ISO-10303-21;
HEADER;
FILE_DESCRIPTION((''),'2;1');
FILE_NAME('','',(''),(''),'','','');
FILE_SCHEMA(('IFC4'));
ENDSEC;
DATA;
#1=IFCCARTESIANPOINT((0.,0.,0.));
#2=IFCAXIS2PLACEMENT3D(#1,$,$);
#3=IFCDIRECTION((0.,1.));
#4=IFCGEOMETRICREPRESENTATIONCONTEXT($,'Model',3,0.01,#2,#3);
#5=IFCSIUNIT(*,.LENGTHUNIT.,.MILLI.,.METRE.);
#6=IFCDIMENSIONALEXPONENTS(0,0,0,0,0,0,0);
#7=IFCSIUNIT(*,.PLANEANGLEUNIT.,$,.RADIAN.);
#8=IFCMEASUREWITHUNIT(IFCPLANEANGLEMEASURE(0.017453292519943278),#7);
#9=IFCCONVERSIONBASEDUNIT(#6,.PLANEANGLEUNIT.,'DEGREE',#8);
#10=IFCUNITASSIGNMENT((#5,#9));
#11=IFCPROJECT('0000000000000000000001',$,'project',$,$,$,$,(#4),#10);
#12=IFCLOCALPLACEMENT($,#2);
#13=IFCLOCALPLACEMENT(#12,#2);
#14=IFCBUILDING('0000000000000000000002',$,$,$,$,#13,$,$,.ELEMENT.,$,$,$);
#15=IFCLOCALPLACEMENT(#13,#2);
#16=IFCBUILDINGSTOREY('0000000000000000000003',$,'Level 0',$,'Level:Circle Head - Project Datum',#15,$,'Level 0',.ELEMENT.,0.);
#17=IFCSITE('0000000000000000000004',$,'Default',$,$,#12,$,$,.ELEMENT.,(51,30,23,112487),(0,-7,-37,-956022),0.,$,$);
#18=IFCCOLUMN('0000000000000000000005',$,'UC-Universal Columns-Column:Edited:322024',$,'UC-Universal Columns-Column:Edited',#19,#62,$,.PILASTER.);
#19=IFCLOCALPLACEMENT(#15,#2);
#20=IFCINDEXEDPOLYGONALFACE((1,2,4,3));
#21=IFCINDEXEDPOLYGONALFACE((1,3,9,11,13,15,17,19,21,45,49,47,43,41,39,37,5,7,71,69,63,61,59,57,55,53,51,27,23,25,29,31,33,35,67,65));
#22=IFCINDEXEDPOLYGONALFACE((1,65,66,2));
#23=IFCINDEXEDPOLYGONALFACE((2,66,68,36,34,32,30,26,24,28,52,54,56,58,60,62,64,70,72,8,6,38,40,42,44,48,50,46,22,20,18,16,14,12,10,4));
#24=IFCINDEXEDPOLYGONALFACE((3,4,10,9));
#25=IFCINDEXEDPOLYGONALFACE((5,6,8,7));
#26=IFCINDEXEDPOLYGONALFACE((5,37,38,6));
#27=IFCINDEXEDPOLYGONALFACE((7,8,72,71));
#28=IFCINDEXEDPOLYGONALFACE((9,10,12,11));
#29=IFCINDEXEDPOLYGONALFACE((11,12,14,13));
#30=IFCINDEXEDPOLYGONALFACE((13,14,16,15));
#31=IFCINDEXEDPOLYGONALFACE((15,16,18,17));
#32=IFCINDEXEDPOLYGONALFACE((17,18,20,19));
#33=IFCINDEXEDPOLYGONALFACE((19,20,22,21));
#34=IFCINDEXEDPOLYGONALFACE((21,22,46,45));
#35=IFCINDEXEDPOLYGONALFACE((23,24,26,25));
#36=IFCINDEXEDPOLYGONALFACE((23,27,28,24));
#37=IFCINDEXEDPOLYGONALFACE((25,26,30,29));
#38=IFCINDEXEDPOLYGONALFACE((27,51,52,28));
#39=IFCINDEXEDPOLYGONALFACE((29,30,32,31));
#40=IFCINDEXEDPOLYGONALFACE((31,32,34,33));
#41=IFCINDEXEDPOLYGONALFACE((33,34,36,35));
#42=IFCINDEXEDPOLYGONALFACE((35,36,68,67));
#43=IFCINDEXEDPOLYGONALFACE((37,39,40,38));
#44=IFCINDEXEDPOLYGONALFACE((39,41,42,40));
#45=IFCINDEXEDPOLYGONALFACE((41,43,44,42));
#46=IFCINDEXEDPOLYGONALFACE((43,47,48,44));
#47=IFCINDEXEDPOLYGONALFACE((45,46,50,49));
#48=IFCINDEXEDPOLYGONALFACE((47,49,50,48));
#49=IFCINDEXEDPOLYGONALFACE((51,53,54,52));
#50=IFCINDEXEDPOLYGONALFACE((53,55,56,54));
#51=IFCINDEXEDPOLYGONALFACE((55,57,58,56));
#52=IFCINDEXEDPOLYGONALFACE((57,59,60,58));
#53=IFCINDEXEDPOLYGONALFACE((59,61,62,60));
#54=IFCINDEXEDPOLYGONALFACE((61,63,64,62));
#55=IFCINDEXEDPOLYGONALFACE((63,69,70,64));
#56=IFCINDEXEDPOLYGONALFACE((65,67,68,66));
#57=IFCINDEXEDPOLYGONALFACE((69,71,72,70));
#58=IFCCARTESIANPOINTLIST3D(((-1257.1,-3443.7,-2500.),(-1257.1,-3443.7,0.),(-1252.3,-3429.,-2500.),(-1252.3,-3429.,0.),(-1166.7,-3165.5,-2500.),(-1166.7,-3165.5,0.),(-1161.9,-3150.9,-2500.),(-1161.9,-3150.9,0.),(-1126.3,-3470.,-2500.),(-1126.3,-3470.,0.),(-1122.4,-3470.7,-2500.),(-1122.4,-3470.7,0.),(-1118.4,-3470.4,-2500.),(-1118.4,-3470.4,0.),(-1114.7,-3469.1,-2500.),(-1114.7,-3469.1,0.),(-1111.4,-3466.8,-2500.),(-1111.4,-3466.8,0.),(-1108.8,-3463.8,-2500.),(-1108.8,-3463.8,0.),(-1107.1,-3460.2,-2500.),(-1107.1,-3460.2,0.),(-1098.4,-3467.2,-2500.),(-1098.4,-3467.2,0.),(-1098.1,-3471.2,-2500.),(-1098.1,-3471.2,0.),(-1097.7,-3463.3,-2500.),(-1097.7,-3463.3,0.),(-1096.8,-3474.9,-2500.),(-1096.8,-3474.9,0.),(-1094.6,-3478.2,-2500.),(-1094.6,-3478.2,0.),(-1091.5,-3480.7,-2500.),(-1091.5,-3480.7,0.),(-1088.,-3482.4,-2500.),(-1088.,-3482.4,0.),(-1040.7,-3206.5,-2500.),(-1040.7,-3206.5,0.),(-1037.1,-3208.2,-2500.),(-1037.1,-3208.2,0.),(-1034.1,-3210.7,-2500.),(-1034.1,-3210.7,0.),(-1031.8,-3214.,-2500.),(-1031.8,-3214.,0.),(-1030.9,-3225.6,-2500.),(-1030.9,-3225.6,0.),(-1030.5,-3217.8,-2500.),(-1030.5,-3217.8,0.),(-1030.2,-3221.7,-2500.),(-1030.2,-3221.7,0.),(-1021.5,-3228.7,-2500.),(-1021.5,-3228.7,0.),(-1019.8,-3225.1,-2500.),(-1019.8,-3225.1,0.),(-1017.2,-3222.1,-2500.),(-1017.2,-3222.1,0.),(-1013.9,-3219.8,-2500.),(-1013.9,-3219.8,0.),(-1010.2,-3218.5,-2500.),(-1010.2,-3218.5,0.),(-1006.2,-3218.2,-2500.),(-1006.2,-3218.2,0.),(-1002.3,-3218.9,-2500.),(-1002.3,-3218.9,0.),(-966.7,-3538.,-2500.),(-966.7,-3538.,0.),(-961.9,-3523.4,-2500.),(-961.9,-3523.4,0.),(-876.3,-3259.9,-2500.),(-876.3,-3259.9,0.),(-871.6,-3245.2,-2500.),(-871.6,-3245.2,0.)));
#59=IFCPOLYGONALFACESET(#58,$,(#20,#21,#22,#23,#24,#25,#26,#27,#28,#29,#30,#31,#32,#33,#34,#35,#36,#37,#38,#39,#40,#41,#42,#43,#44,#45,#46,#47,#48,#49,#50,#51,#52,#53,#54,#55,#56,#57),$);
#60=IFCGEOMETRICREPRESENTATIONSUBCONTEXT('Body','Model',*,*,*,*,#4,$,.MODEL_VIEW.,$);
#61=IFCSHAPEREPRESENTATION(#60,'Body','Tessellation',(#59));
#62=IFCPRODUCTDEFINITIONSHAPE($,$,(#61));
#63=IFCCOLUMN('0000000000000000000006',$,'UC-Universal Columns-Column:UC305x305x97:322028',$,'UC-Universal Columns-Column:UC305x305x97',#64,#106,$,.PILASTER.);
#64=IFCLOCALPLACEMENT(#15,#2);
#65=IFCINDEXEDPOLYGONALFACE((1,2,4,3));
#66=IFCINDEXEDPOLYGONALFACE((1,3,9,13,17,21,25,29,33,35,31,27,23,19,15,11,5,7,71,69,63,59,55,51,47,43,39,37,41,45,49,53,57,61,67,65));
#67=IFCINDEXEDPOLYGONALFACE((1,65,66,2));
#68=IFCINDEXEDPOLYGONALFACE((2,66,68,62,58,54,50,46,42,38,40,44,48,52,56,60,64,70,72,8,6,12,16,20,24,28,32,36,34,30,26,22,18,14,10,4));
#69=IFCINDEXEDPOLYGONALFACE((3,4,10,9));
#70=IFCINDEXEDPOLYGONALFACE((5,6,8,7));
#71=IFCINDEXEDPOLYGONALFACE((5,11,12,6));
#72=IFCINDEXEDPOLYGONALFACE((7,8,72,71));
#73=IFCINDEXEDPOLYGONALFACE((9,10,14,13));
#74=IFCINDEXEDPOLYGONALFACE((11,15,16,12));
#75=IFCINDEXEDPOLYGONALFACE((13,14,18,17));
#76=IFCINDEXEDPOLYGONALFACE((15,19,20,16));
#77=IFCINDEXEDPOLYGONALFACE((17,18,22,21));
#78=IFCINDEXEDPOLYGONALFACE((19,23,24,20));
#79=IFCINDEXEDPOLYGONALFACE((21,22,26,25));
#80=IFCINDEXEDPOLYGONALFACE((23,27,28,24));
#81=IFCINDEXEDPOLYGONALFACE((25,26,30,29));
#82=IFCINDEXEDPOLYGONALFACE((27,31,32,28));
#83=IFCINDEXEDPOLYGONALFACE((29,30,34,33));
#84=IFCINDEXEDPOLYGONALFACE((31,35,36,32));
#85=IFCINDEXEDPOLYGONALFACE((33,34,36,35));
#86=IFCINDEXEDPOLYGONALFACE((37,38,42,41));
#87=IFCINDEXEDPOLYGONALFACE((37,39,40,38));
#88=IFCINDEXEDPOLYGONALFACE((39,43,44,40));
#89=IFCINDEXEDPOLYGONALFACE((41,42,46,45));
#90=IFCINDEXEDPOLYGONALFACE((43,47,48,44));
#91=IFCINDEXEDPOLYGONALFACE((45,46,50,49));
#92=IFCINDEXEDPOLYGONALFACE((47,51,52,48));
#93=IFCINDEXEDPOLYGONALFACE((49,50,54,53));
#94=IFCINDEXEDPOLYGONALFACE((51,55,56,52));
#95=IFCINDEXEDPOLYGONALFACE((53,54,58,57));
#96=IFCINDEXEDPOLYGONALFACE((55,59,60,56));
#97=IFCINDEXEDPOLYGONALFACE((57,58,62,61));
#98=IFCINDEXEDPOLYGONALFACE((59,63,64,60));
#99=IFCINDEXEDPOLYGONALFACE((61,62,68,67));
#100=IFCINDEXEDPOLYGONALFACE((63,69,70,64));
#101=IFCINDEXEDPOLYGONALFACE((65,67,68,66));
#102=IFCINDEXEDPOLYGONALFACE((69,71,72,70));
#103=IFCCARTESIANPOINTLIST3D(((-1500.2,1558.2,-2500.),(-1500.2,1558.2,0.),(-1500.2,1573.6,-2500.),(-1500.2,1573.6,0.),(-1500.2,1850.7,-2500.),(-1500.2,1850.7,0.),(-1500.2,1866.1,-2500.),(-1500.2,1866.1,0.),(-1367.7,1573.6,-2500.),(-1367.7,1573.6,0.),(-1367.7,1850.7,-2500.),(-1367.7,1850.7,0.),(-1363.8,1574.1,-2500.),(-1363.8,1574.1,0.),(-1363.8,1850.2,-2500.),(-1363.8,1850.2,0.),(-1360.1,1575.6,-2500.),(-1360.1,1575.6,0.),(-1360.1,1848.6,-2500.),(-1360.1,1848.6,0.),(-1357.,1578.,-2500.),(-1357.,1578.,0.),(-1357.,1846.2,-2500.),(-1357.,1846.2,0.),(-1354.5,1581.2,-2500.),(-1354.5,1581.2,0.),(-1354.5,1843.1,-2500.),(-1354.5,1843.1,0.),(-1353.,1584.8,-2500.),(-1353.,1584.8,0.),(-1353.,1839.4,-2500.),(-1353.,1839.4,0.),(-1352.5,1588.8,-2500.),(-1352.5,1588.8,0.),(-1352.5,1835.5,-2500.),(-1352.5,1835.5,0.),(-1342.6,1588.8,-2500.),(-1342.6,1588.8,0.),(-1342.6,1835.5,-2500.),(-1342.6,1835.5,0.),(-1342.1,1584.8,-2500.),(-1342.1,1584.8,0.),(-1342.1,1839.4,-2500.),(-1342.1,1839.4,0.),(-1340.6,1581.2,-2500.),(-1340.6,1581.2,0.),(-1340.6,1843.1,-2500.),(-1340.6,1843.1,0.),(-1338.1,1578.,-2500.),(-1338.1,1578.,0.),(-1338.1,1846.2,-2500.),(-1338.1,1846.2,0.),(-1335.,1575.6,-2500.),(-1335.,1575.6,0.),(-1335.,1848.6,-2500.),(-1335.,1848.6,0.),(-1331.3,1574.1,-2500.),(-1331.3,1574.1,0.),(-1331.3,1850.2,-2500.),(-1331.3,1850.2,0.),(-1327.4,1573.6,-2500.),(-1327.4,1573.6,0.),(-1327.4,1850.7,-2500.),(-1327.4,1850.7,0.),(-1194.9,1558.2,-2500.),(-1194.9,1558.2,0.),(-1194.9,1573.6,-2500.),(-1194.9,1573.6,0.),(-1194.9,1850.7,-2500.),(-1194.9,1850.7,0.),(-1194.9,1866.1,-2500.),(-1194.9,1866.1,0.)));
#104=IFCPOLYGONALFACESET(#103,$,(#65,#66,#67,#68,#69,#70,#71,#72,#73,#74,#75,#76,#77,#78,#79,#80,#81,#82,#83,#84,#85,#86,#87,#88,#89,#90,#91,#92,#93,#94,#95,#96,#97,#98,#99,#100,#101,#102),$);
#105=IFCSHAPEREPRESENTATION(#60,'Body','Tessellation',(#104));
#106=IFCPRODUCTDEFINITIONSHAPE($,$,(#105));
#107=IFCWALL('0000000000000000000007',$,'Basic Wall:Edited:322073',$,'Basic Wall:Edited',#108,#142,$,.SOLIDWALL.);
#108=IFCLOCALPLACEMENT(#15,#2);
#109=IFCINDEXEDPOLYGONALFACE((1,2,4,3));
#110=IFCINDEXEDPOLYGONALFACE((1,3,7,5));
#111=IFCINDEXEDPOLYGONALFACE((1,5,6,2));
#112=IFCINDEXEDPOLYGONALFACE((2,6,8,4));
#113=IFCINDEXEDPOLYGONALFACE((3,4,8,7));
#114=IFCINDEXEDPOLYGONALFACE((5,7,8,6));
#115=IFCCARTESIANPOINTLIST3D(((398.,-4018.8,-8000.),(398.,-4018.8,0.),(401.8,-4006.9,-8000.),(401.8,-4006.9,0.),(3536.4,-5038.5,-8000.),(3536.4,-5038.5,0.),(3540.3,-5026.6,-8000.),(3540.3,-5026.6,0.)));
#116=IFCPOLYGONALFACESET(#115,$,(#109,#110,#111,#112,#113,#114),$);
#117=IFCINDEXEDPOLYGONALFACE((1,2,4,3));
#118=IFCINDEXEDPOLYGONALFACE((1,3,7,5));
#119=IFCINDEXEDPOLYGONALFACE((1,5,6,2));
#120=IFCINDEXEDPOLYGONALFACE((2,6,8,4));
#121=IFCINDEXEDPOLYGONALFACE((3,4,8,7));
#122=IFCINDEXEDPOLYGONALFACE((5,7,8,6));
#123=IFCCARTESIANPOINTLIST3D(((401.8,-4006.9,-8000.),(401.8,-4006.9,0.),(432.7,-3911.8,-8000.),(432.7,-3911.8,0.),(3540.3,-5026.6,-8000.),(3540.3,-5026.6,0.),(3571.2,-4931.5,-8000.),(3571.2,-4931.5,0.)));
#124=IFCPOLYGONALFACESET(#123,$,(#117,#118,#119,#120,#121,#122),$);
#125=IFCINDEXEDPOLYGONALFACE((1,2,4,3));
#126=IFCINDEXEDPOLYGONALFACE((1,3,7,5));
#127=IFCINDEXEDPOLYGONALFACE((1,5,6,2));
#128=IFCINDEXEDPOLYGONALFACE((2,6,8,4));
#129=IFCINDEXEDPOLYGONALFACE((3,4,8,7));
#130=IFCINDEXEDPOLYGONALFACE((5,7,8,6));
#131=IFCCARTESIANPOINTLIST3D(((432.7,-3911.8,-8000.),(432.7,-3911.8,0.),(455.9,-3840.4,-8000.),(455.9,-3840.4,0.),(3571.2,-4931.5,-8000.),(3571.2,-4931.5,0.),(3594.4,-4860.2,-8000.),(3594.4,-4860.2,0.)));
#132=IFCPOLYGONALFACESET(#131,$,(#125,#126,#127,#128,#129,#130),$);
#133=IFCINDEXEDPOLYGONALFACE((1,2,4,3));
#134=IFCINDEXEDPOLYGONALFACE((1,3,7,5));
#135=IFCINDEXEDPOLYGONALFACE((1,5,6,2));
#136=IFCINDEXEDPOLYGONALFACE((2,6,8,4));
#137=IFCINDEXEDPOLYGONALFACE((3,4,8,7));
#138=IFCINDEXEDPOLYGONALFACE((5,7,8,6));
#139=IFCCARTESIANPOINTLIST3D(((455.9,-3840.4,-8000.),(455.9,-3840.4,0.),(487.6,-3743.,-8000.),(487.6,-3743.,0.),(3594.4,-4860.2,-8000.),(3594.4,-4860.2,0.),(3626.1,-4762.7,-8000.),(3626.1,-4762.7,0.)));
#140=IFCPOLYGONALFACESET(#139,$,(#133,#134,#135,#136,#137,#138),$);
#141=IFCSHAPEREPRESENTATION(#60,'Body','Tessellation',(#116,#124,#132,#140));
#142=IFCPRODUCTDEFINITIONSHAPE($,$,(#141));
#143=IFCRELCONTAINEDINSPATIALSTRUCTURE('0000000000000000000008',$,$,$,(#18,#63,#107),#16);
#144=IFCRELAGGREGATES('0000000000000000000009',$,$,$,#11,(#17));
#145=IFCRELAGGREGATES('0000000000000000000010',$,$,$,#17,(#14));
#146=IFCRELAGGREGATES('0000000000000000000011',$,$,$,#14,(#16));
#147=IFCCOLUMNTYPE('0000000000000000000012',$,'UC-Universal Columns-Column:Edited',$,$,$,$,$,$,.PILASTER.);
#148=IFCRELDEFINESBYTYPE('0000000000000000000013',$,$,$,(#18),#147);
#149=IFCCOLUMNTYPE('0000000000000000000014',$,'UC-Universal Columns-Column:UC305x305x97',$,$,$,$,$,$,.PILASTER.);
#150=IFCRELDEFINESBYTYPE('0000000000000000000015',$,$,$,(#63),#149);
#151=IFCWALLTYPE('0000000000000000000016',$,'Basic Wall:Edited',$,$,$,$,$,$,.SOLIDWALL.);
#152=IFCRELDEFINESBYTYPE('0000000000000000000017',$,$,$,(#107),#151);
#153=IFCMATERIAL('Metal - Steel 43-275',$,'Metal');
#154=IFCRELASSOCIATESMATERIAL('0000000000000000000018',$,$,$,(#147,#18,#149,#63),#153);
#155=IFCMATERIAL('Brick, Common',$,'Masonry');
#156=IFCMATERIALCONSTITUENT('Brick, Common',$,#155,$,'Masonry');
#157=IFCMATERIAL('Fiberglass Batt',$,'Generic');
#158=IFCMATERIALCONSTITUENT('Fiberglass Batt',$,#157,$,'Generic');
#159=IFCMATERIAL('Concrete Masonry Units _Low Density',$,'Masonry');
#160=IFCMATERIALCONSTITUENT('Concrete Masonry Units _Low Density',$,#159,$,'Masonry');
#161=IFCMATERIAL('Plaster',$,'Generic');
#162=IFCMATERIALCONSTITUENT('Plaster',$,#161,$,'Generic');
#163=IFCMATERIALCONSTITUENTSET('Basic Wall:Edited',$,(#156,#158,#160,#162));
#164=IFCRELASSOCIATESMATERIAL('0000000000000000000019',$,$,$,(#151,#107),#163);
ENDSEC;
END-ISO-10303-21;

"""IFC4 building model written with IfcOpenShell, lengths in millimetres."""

from ifc_helpers import new_model, entity, si_unit, converted_unit, direction, frame, origin, place, context, subcontext, project, spatial, line, arc, indexed_curve, outline, extrude, source, transform, mapped, material, constituent, constituent_set, type_object, type_shapes, element, save


model = new_model("IFC4")

# Units and contexts
model_context = context("Model", 3, precision=0.01, world=origin(), true_north=direction((0.0, 1.0)))
body_context = subcontext(model_context, "Body", "Model", "MODEL_VIEW")
ifc_project = project(units=[si_unit("LENGTHUNIT", "METRE", prefix="MILLI"), converted_unit("PLANEANGLEUNIT", "DEGREE", entity("IfcPlaneAngleMeasure", 0.017453292519943278), si_unit("PLANEANGLEUNIT", "RADIAN"), dimensions=[0, 0, 0, 0, 0, 0, 0])], contexts=[model_context])

# Site, building, storey
site_placement = place(None, origin())
site = spatial("IfcSite", under=ifc_project, at=site_placement, Name="Default", CompositionType="ELEMENT", RefLatitude=(51, 30, 23, 112487), RefLongitude=(0, -7, -37, -956022), RefElevation=0.0)
building_placement = place(site_placement, origin())
building = spatial("IfcBuilding", under=site, at=building_placement, CompositionType="ELEMENT")
storey_placement = place(building_placement, origin())
storey = spatial("IfcBuildingStorey", under=building, at=storey_placement, Name="Level 0", ObjectType="Level:Circle Head - Project Datum", LongName="Level 0", CompositionType="ELEMENT", Elevation=0.0)

# Columns
ifc_material_1 = material(Name="Metal - Steel 43-275", Category="Metal")
column_type_1 = type_object("IfcColumnType", Name="UC-Universal Columns-Column:Edited", PredefinedType="PILASTER", material=ifc_material_1)
shared_shape_1 = source(origin(), body_context, "Body", "SweptSolid", [
    extrude(outline(indexed_curve([(-152.6, -153.9), (152.6, -153.9), (152.6, -138.5), (20.2, -138.5), (9.4, -134.1), (4.9, -123.4), (4.9, 123.3), (9.4, 134.1), (20.1, 138.5), (152.6, 138.5), (152.6, 153.9), (-152.6, 153.9), (-152.6, 138.5), (-20.2, 138.6), (-9.4, 134.1), (-5.0, 123.4), (-5.0, -123.3), (-9.4, -134.1), (-20.2, -138.5), (-152.6, -138.5)], segments=[line(1, 2, 3, 4), arc(4, 5, 6), line(6, 7), arc(7, 8, 9), line(9, 10, 11, 12, 13, 14), arc(14, 15, 16), line(16, 17), arc(17, 18, 19), line(19, 20, 1)], self_intersect=False)), frame((0.0, 0.0, -2500.0), z_axis=(0.0, 0.0, 1.0), x_axis=(-1.0, 0.0, 0.0)), (0.0, 0.0, 1.0), 2500.0),
])
type_shapes(column_type_1, [shared_shape_1])
column_1_placement = place(storey_placement, frame((-1064.3, -3344.5, 0.0), z_axis=(0.0, 0.0, 1.0), x_axis=(0.951057, -0.309017, 0.0)))
element("IfcColumn", 1, at=column_1_placement, inside=storey, type_object=column_type_1, material=ifc_material_1, Name="UC-Universal Columns-Column:Edited:322024", ObjectType="UC-Universal Columns-Column:Edited", PredefinedType="PILASTER", context=body_context, shape_type="MappedRepresentation", body=[
    mapped(shared_shape_1, transform((0.0, 0.0, 0.0), scale=1.0)),
])
column_type_2 = type_object("IfcColumnType", Name="UC-Universal Columns-Column:UC305x305x97", PredefinedType="PILASTER", material=ifc_material_1)
shared_shape_2 = source(origin(), body_context, "Body", "SweptSolid", [
    extrude(outline(indexed_curve([(-152.6, -153.9), (152.6, -153.9), (152.6, -138.5), (20.2, -138.5), (9.4, -134.1), (4.9, -123.4), (4.9, 123.3), (9.4, 134.1), (20.1, 138.5), (152.6, 138.5), (152.6, 153.9), (-152.6, 153.9), (-152.6, 138.5), (-20.2, 138.6), (-9.4, 134.1), (-5.0, 123.4), (-5.0, -123.3), (-9.4, -134.1), (-20.2, -138.5), (-152.6, -138.5)], segments=[line(1, 2, 3, 4), arc(4, 5, 6), line(6, 7), arc(7, 8, 9), line(9, 10, 11, 12, 13, 14), arc(14, 15, 16), line(16, 17), arc(17, 18, 19), line(19, 20, 1)], self_intersect=False)), frame((0.0, 0.0, -2500.0), z_axis=(0.0, 0.0, 1.0), x_axis=(-1.0, 0.0, 0.0)), (0.0, 0.0, 1.0), 2500.0),
])
type_shapes(column_type_2, [shared_shape_2])
column_2_placement = place(storey_placement, frame((-1347.5, 1712.1, 0.0)))
element("IfcColumn", 2, at=column_2_placement, inside=storey, type_object=column_type_2, material=ifc_material_1, Name="UC-Universal Columns-Column:UC305x305x97:322028", ObjectType="UC-Universal Columns-Column:UC305x305x97", PredefinedType="PILASTER", context=body_context, shape_type="MappedRepresentation", body=[
    mapped(shared_shape_2, transform((0.0, 0.0, 0.0), scale=1.0)),
])

# Wall
ifc_material_2 = material(Name="Brick, Common", Category="Masonry")
ifc_constituent_1 = constituent(ifc_material_2, Name="Brick, Common", Category="Masonry")
ifc_material_3 = material(Name="Fiberglass Batt", Category="Generic")
ifc_constituent_2 = constituent(ifc_material_3, Name="Fiberglass Batt", Category="Generic")
ifc_material_4 = material(Name="Concrete Masonry Units _Low Density", Category="Masonry")
ifc_constituent_3 = constituent(ifc_material_4, Name="Concrete Masonry Units _Low Density", Category="Masonry")
ifc_material_5 = material(Name="Plaster", Category="Generic")
ifc_constituent_4 = constituent(ifc_material_5, Name="Plaster", Category="Generic")
ifc_constituent_set_1 = constituent_set(constituents=[ifc_constituent_1, ifc_constituent_2, ifc_constituent_3, ifc_constituent_4], Name="Basic Wall:Edited")
wall_type_1 = type_object("IfcWallType", Name="Basic Wall:Edited", PredefinedType="SOLIDWALL", material=ifc_constituent_set_1)
wall_1_placement = place(storey_placement, frame((442.8, -3880.9, -8000.0), z_axis=(0.0, 0.0, 1.0), x_axis=(0.951057, -0.309017, 0.0)))
element("IfcWall", 3, at=wall_1_placement, inside=storey, type_object=wall_type_1, material=ifc_constituent_set_1, Name="Basic Wall:Edited:322073", ObjectType="Basic Wall:Edited", PredefinedType="SOLIDWALL", context=body_context, shape_type="SweptSolid", body=[
    extrude(outline(indexed_curve([(-6.2, -1650.0), (6.3, -1650.0), (6.2, 1650.0), (-6.3, 1650.0), (-6.2, -1650.0)], self_intersect=False)), frame((1650.0, -138.8, 0.0), z_axis=(0.0, 0.0, 1.0), x_axis=(0.0, 1.0, 0.0)), (0.0, 0.0, 1.0), 8000.0),
    extrude(outline(indexed_curve([(-1650.0, -50.0), (1650.0, -50.0), (1650.0, 50.0), (-1650.0, 50.0), (-1650.0, -50.0)], self_intersect=False)), frame((1650.0, -82.5, 0.0)), (0.0, 0.0, 1.0), 8000.0),
    extrude(outline(indexed_curve([(-1650.0, -37.5), (1650.0, -37.5), (1650.0, 37.5), (-1650.0, 37.5), (-1650.0, -37.5)], self_intersect=False)), frame((1650.0, 5.0, 0.0)), (0.0, 0.0, 1.0), 8000.0),
    extrude(outline(indexed_curve([(-51.2, -1650.0), (51.3, -1650.0), (51.2, 1650.0), (-51.3, 1650.0), (-51.2, -1650.0)], self_intersect=False)), frame((1650.0, 93.8, 0.0), z_axis=(0.0, 0.0, 1.0), x_axis=(0.0, -1.0, 0.0)), (0.0, 0.0, 1.0), 8000.0),
])

save(model, "model.ifc")
